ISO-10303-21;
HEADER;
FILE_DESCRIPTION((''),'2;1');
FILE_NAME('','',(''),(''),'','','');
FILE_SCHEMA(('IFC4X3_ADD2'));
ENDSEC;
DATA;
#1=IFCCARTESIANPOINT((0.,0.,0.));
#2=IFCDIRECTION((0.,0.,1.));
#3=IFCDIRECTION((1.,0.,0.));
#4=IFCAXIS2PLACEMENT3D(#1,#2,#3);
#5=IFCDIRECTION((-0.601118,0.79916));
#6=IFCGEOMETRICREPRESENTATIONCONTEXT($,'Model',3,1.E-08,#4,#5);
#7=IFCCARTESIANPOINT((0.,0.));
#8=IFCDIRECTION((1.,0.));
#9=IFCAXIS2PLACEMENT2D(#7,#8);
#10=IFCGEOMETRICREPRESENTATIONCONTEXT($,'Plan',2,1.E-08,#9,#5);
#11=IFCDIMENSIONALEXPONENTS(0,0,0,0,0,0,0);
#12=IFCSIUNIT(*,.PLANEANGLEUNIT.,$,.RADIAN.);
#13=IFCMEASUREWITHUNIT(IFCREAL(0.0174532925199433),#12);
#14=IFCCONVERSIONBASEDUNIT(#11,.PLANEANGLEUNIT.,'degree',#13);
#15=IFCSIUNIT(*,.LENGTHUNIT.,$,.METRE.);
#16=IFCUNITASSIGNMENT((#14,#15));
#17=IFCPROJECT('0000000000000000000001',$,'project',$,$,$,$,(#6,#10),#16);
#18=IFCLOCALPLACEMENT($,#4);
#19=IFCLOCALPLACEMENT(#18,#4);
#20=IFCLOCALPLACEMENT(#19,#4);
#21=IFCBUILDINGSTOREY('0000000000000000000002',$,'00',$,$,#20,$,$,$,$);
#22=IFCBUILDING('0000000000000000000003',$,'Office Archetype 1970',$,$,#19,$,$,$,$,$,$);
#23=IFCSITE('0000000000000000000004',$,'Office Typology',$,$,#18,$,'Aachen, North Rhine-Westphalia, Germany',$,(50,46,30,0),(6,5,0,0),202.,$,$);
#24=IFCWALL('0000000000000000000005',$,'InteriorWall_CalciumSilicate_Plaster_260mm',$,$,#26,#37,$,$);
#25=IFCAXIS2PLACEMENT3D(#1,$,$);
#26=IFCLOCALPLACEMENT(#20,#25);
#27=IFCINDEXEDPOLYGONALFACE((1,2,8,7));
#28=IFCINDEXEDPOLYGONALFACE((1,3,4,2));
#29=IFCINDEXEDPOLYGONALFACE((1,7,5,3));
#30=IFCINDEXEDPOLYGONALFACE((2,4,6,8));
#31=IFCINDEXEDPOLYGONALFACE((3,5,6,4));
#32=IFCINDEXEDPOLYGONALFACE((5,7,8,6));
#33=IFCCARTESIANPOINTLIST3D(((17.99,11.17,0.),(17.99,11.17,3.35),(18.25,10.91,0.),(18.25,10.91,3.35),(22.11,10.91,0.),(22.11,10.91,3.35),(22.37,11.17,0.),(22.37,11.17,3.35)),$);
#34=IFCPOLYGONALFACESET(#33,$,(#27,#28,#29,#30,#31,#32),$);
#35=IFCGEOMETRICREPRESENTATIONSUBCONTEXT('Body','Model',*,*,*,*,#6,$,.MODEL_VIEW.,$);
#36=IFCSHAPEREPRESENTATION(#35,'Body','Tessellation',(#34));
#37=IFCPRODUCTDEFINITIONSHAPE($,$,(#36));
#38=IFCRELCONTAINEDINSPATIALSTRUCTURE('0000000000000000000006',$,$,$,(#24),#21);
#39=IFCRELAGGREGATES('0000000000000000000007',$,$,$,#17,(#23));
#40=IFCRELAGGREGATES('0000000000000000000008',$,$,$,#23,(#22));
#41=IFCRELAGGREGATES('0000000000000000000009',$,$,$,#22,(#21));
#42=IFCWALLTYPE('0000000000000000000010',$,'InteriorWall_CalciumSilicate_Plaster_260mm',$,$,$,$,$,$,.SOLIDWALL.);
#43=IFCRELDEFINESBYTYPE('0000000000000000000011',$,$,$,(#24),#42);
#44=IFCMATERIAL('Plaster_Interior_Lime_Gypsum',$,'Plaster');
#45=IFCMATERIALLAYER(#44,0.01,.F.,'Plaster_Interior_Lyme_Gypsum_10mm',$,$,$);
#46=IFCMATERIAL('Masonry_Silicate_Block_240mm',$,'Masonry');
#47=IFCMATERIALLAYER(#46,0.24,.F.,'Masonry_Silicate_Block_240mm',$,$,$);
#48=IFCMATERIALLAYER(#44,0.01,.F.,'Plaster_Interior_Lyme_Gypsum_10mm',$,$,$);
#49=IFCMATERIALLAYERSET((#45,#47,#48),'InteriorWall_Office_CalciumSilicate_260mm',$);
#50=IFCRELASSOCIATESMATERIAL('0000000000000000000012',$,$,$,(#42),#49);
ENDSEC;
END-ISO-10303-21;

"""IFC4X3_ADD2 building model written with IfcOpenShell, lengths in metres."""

from ifc_helpers import new_model, entity, si_unit, converted_unit, direction, frame, origin_with_axes, origin_2d_with_axis, place, context, subcontext, project, spatial, line, indexed_curve, outline, extrude, material, layer, layer_set, type_object, element, save


model = new_model("IFC4X3_ADD2")

# Units and contexts
model_context = context("Model", 3, precision=1e-08, world=origin_with_axes(), true_north=direction((-0.601118, 0.79916)))
plan_context = context("Plan", 2, precision=1e-08, world=origin_2d_with_axis(), true_north=direction((-0.601118, 0.79916)))
body_context = subcontext(model_context, "Body", "Model", "MODEL_VIEW")
ifc_project = project(units=[converted_unit("PLANEANGLEUNIT", "degree", entity("IfcReal", 0.0174532925199433), si_unit("PLANEANGLEUNIT", "RADIAN"), dimensions=[0, 0, 0, 0, 0, 0, 0]), si_unit("LENGTHUNIT", "METRE")], contexts=[model_context, plan_context])

# Site, building, storey
site_placement = place(None, origin_with_axes())
site = spatial("IfcSite", under=ifc_project, at=site_placement, Name="Office Typology", LongName="Aachen, North Rhine-Westphalia, Germany", RefLatitude=(50, 46, 30, 0), RefLongitude=(6, 5, 0, 0), RefElevation=202.0)
building_placement = place(site_placement, origin_with_axes())
building = spatial("IfcBuilding", under=site, at=building_placement, Name="Office Archetype 1970")
storey_placement = place(building_placement, origin_with_axes())
storey = spatial("IfcBuildingStorey", under=building, at=storey_placement, Name="00")

# Wall
ifc_material_1 = material(Name="Plaster_Interior_Lime_Gypsum", Category="Plaster")
ifc_layer_1 = layer(ifc_material_1, 0.01, ventilated=False, Name="Plaster_Interior_Lyme_Gypsum_10mm")
ifc_material_2 = material(Name="Masonry_Silicate_Block_240mm", Category="Masonry")
ifc_layer_2 = layer(ifc_material_2, 0.24, ventilated=False, Name="Masonry_Silicate_Block_240mm")
ifc_layer_3 = layer(ifc_material_1, 0.01, ventilated=False, Name="Plaster_Interior_Lyme_Gypsum_10mm")
ifc_layer_set_1 = layer_set([ifc_layer_1, ifc_layer_2, ifc_layer_3], Name="InteriorWall_Office_CalciumSilicate_260mm")
wall_type_1 = type_object("IfcWallType", Name="InteriorWall_CalciumSilicate_Plaster_260mm", PredefinedType="SOLIDWALL", material=ifc_layer_set_1)
wall_1_placement = place(storey_placement, frame((22.37, 11.17, 0.0), z_axis=(0.0, 0.0, 1.0), x_axis=(-1.0, 0.0, 0.0)))
element("IfcWall", 1, at=wall_1_placement, inside=storey, type_object=wall_type_1, Name="InteriorWall_CalciumSilicate_Plaster_260mm", context=body_context, shape_type="SweptSolid", body=[
    extrude(outline(indexed_curve([(0.0, 0.0), (0.26, 0.26), (4.12, 0.26), (4.38, 0.0)], segments=[line(1, 2, 3, 4, 1)])), origin_with_axes(), (0.0, 0.0, 1.0), 3.35),
])

save(model, "model.ifc")
